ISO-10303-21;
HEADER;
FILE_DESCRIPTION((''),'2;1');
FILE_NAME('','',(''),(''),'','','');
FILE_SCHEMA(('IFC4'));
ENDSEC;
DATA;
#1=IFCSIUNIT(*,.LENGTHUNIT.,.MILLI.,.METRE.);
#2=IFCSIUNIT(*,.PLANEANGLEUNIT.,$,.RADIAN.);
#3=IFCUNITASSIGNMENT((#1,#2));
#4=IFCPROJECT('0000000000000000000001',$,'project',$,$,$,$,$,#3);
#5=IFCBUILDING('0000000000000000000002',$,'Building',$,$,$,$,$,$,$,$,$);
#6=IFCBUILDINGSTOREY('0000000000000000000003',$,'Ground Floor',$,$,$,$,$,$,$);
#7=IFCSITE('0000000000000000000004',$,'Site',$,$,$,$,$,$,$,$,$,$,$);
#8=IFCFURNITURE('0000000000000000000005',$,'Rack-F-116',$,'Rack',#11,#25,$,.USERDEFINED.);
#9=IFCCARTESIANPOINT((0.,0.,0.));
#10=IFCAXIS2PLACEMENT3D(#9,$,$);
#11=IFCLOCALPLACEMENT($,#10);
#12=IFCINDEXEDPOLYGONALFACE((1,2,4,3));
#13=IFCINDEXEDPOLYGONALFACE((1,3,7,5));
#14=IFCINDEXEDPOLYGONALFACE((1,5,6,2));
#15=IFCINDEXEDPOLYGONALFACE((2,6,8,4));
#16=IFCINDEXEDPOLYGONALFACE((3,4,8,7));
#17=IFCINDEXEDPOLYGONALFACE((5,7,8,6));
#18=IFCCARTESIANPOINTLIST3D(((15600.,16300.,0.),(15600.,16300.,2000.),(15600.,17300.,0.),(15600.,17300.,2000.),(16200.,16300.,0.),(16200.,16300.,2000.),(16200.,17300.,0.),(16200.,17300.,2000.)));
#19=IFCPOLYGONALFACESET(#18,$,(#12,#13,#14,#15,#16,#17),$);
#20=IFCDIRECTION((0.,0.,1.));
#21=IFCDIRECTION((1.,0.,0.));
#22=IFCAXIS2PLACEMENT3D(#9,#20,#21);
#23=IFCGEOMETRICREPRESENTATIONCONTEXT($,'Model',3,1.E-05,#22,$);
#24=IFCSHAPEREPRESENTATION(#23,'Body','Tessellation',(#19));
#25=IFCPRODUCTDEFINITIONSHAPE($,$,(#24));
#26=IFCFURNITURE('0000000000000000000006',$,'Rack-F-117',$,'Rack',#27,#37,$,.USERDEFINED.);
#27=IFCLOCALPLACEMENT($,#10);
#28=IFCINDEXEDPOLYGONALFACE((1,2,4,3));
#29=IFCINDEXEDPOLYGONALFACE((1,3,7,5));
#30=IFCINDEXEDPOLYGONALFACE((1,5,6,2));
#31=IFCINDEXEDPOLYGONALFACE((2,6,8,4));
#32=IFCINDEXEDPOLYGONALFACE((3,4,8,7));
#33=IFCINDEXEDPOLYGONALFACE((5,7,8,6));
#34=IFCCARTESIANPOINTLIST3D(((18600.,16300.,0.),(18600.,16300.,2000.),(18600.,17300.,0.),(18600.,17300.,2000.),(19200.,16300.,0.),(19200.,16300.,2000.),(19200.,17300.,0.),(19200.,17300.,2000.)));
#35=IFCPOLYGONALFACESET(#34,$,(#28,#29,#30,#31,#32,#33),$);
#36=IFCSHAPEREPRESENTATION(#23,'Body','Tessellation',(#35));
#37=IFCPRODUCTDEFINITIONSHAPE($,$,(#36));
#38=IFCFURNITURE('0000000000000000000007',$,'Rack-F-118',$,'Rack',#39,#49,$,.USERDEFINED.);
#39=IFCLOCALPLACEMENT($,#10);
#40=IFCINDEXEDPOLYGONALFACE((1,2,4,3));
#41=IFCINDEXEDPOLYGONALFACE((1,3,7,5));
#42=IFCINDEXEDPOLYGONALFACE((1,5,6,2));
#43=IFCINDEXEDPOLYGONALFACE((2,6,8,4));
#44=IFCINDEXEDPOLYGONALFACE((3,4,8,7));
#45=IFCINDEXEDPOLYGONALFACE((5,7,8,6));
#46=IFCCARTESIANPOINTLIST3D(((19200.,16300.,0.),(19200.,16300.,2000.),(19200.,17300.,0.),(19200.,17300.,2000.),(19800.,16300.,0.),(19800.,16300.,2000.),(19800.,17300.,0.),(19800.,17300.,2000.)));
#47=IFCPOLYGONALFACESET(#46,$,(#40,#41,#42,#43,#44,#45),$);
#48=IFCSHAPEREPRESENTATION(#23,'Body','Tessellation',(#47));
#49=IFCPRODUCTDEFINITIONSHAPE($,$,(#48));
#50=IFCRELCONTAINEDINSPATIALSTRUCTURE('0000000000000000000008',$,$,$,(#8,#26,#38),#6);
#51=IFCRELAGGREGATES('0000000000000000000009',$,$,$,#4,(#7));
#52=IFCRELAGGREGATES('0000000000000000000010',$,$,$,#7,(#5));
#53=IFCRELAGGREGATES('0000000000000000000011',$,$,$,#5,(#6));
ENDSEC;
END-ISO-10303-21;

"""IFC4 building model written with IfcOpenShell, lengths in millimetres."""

from ifc_helpers import new_model, si_unit, frame, origin_with_axes, place, context, project, spatial, rectangle, extrude, element, save


model = new_model("IFC4")

# Units and contexts
model_context = context("Model", 3, precision=1e-05, world=origin_with_axes())
ifc_project = project(units=[si_unit("LENGTHUNIT", "METRE", prefix="MILLI"), si_unit("PLANEANGLEUNIT", "RADIAN")])

# Site, building, storey
site = spatial("IfcSite", under=ifc_project, Name="Site")
building = spatial("IfcBuilding", under=site, Name="Building")
storey = spatial("IfcBuildingStorey", under=building, Name="Ground Floor")

# Furniture
furniture_1_placement = place(None, origin_with_axes())
element("IfcFurniture", 1, at=furniture_1_placement, inside=storey, Name="Rack-F-116", ObjectType="Rack", PredefinedType="USERDEFINED", context=model_context, shape_type="SweptSolid", body=[
    extrude(rectangle(XDim=600.0, YDim=1000.0), frame((15900.0, 16800.0, 0.0), z_axis=(0.0, 0.0, 1.0), x_axis=(1.0, 0.0, 0.0)), (0.0, 0.0, 1.0), 2000.0),
])
furniture_2_placement = place(None, origin_with_axes())
element("IfcFurniture", 2, at=furniture_2_placement, inside=storey, Name="Rack-F-117", ObjectType="Rack", PredefinedType="USERDEFINED", context=model_context, shape_type="SweptSolid", body=[
    extrude(rectangle(XDim=600.0, YDim=1000.0), frame((18900.0, 16800.0, 0.0), z_axis=(0.0, 0.0, 1.0), x_axis=(1.0, 0.0, 0.0)), (0.0, 0.0, 1.0), 2000.0),
])
furniture_3_placement = place(None, origin_with_axes())
element("IfcFurniture", 3, at=furniture_3_placement, inside=storey, Name="Rack-F-118", ObjectType="Rack", PredefinedType="USERDEFINED", context=model_context, shape_type="SweptSolid", body=[
    extrude(rectangle(XDim=600.0, YDim=1000.0), frame((19500.0, 16800.0, 0.0), z_axis=(0.0, 0.0, 1.0), x_axis=(1.0, 0.0, 0.0)), (0.0, 0.0, 1.0), 2000.0),
])

save(model, "model.ifc")
